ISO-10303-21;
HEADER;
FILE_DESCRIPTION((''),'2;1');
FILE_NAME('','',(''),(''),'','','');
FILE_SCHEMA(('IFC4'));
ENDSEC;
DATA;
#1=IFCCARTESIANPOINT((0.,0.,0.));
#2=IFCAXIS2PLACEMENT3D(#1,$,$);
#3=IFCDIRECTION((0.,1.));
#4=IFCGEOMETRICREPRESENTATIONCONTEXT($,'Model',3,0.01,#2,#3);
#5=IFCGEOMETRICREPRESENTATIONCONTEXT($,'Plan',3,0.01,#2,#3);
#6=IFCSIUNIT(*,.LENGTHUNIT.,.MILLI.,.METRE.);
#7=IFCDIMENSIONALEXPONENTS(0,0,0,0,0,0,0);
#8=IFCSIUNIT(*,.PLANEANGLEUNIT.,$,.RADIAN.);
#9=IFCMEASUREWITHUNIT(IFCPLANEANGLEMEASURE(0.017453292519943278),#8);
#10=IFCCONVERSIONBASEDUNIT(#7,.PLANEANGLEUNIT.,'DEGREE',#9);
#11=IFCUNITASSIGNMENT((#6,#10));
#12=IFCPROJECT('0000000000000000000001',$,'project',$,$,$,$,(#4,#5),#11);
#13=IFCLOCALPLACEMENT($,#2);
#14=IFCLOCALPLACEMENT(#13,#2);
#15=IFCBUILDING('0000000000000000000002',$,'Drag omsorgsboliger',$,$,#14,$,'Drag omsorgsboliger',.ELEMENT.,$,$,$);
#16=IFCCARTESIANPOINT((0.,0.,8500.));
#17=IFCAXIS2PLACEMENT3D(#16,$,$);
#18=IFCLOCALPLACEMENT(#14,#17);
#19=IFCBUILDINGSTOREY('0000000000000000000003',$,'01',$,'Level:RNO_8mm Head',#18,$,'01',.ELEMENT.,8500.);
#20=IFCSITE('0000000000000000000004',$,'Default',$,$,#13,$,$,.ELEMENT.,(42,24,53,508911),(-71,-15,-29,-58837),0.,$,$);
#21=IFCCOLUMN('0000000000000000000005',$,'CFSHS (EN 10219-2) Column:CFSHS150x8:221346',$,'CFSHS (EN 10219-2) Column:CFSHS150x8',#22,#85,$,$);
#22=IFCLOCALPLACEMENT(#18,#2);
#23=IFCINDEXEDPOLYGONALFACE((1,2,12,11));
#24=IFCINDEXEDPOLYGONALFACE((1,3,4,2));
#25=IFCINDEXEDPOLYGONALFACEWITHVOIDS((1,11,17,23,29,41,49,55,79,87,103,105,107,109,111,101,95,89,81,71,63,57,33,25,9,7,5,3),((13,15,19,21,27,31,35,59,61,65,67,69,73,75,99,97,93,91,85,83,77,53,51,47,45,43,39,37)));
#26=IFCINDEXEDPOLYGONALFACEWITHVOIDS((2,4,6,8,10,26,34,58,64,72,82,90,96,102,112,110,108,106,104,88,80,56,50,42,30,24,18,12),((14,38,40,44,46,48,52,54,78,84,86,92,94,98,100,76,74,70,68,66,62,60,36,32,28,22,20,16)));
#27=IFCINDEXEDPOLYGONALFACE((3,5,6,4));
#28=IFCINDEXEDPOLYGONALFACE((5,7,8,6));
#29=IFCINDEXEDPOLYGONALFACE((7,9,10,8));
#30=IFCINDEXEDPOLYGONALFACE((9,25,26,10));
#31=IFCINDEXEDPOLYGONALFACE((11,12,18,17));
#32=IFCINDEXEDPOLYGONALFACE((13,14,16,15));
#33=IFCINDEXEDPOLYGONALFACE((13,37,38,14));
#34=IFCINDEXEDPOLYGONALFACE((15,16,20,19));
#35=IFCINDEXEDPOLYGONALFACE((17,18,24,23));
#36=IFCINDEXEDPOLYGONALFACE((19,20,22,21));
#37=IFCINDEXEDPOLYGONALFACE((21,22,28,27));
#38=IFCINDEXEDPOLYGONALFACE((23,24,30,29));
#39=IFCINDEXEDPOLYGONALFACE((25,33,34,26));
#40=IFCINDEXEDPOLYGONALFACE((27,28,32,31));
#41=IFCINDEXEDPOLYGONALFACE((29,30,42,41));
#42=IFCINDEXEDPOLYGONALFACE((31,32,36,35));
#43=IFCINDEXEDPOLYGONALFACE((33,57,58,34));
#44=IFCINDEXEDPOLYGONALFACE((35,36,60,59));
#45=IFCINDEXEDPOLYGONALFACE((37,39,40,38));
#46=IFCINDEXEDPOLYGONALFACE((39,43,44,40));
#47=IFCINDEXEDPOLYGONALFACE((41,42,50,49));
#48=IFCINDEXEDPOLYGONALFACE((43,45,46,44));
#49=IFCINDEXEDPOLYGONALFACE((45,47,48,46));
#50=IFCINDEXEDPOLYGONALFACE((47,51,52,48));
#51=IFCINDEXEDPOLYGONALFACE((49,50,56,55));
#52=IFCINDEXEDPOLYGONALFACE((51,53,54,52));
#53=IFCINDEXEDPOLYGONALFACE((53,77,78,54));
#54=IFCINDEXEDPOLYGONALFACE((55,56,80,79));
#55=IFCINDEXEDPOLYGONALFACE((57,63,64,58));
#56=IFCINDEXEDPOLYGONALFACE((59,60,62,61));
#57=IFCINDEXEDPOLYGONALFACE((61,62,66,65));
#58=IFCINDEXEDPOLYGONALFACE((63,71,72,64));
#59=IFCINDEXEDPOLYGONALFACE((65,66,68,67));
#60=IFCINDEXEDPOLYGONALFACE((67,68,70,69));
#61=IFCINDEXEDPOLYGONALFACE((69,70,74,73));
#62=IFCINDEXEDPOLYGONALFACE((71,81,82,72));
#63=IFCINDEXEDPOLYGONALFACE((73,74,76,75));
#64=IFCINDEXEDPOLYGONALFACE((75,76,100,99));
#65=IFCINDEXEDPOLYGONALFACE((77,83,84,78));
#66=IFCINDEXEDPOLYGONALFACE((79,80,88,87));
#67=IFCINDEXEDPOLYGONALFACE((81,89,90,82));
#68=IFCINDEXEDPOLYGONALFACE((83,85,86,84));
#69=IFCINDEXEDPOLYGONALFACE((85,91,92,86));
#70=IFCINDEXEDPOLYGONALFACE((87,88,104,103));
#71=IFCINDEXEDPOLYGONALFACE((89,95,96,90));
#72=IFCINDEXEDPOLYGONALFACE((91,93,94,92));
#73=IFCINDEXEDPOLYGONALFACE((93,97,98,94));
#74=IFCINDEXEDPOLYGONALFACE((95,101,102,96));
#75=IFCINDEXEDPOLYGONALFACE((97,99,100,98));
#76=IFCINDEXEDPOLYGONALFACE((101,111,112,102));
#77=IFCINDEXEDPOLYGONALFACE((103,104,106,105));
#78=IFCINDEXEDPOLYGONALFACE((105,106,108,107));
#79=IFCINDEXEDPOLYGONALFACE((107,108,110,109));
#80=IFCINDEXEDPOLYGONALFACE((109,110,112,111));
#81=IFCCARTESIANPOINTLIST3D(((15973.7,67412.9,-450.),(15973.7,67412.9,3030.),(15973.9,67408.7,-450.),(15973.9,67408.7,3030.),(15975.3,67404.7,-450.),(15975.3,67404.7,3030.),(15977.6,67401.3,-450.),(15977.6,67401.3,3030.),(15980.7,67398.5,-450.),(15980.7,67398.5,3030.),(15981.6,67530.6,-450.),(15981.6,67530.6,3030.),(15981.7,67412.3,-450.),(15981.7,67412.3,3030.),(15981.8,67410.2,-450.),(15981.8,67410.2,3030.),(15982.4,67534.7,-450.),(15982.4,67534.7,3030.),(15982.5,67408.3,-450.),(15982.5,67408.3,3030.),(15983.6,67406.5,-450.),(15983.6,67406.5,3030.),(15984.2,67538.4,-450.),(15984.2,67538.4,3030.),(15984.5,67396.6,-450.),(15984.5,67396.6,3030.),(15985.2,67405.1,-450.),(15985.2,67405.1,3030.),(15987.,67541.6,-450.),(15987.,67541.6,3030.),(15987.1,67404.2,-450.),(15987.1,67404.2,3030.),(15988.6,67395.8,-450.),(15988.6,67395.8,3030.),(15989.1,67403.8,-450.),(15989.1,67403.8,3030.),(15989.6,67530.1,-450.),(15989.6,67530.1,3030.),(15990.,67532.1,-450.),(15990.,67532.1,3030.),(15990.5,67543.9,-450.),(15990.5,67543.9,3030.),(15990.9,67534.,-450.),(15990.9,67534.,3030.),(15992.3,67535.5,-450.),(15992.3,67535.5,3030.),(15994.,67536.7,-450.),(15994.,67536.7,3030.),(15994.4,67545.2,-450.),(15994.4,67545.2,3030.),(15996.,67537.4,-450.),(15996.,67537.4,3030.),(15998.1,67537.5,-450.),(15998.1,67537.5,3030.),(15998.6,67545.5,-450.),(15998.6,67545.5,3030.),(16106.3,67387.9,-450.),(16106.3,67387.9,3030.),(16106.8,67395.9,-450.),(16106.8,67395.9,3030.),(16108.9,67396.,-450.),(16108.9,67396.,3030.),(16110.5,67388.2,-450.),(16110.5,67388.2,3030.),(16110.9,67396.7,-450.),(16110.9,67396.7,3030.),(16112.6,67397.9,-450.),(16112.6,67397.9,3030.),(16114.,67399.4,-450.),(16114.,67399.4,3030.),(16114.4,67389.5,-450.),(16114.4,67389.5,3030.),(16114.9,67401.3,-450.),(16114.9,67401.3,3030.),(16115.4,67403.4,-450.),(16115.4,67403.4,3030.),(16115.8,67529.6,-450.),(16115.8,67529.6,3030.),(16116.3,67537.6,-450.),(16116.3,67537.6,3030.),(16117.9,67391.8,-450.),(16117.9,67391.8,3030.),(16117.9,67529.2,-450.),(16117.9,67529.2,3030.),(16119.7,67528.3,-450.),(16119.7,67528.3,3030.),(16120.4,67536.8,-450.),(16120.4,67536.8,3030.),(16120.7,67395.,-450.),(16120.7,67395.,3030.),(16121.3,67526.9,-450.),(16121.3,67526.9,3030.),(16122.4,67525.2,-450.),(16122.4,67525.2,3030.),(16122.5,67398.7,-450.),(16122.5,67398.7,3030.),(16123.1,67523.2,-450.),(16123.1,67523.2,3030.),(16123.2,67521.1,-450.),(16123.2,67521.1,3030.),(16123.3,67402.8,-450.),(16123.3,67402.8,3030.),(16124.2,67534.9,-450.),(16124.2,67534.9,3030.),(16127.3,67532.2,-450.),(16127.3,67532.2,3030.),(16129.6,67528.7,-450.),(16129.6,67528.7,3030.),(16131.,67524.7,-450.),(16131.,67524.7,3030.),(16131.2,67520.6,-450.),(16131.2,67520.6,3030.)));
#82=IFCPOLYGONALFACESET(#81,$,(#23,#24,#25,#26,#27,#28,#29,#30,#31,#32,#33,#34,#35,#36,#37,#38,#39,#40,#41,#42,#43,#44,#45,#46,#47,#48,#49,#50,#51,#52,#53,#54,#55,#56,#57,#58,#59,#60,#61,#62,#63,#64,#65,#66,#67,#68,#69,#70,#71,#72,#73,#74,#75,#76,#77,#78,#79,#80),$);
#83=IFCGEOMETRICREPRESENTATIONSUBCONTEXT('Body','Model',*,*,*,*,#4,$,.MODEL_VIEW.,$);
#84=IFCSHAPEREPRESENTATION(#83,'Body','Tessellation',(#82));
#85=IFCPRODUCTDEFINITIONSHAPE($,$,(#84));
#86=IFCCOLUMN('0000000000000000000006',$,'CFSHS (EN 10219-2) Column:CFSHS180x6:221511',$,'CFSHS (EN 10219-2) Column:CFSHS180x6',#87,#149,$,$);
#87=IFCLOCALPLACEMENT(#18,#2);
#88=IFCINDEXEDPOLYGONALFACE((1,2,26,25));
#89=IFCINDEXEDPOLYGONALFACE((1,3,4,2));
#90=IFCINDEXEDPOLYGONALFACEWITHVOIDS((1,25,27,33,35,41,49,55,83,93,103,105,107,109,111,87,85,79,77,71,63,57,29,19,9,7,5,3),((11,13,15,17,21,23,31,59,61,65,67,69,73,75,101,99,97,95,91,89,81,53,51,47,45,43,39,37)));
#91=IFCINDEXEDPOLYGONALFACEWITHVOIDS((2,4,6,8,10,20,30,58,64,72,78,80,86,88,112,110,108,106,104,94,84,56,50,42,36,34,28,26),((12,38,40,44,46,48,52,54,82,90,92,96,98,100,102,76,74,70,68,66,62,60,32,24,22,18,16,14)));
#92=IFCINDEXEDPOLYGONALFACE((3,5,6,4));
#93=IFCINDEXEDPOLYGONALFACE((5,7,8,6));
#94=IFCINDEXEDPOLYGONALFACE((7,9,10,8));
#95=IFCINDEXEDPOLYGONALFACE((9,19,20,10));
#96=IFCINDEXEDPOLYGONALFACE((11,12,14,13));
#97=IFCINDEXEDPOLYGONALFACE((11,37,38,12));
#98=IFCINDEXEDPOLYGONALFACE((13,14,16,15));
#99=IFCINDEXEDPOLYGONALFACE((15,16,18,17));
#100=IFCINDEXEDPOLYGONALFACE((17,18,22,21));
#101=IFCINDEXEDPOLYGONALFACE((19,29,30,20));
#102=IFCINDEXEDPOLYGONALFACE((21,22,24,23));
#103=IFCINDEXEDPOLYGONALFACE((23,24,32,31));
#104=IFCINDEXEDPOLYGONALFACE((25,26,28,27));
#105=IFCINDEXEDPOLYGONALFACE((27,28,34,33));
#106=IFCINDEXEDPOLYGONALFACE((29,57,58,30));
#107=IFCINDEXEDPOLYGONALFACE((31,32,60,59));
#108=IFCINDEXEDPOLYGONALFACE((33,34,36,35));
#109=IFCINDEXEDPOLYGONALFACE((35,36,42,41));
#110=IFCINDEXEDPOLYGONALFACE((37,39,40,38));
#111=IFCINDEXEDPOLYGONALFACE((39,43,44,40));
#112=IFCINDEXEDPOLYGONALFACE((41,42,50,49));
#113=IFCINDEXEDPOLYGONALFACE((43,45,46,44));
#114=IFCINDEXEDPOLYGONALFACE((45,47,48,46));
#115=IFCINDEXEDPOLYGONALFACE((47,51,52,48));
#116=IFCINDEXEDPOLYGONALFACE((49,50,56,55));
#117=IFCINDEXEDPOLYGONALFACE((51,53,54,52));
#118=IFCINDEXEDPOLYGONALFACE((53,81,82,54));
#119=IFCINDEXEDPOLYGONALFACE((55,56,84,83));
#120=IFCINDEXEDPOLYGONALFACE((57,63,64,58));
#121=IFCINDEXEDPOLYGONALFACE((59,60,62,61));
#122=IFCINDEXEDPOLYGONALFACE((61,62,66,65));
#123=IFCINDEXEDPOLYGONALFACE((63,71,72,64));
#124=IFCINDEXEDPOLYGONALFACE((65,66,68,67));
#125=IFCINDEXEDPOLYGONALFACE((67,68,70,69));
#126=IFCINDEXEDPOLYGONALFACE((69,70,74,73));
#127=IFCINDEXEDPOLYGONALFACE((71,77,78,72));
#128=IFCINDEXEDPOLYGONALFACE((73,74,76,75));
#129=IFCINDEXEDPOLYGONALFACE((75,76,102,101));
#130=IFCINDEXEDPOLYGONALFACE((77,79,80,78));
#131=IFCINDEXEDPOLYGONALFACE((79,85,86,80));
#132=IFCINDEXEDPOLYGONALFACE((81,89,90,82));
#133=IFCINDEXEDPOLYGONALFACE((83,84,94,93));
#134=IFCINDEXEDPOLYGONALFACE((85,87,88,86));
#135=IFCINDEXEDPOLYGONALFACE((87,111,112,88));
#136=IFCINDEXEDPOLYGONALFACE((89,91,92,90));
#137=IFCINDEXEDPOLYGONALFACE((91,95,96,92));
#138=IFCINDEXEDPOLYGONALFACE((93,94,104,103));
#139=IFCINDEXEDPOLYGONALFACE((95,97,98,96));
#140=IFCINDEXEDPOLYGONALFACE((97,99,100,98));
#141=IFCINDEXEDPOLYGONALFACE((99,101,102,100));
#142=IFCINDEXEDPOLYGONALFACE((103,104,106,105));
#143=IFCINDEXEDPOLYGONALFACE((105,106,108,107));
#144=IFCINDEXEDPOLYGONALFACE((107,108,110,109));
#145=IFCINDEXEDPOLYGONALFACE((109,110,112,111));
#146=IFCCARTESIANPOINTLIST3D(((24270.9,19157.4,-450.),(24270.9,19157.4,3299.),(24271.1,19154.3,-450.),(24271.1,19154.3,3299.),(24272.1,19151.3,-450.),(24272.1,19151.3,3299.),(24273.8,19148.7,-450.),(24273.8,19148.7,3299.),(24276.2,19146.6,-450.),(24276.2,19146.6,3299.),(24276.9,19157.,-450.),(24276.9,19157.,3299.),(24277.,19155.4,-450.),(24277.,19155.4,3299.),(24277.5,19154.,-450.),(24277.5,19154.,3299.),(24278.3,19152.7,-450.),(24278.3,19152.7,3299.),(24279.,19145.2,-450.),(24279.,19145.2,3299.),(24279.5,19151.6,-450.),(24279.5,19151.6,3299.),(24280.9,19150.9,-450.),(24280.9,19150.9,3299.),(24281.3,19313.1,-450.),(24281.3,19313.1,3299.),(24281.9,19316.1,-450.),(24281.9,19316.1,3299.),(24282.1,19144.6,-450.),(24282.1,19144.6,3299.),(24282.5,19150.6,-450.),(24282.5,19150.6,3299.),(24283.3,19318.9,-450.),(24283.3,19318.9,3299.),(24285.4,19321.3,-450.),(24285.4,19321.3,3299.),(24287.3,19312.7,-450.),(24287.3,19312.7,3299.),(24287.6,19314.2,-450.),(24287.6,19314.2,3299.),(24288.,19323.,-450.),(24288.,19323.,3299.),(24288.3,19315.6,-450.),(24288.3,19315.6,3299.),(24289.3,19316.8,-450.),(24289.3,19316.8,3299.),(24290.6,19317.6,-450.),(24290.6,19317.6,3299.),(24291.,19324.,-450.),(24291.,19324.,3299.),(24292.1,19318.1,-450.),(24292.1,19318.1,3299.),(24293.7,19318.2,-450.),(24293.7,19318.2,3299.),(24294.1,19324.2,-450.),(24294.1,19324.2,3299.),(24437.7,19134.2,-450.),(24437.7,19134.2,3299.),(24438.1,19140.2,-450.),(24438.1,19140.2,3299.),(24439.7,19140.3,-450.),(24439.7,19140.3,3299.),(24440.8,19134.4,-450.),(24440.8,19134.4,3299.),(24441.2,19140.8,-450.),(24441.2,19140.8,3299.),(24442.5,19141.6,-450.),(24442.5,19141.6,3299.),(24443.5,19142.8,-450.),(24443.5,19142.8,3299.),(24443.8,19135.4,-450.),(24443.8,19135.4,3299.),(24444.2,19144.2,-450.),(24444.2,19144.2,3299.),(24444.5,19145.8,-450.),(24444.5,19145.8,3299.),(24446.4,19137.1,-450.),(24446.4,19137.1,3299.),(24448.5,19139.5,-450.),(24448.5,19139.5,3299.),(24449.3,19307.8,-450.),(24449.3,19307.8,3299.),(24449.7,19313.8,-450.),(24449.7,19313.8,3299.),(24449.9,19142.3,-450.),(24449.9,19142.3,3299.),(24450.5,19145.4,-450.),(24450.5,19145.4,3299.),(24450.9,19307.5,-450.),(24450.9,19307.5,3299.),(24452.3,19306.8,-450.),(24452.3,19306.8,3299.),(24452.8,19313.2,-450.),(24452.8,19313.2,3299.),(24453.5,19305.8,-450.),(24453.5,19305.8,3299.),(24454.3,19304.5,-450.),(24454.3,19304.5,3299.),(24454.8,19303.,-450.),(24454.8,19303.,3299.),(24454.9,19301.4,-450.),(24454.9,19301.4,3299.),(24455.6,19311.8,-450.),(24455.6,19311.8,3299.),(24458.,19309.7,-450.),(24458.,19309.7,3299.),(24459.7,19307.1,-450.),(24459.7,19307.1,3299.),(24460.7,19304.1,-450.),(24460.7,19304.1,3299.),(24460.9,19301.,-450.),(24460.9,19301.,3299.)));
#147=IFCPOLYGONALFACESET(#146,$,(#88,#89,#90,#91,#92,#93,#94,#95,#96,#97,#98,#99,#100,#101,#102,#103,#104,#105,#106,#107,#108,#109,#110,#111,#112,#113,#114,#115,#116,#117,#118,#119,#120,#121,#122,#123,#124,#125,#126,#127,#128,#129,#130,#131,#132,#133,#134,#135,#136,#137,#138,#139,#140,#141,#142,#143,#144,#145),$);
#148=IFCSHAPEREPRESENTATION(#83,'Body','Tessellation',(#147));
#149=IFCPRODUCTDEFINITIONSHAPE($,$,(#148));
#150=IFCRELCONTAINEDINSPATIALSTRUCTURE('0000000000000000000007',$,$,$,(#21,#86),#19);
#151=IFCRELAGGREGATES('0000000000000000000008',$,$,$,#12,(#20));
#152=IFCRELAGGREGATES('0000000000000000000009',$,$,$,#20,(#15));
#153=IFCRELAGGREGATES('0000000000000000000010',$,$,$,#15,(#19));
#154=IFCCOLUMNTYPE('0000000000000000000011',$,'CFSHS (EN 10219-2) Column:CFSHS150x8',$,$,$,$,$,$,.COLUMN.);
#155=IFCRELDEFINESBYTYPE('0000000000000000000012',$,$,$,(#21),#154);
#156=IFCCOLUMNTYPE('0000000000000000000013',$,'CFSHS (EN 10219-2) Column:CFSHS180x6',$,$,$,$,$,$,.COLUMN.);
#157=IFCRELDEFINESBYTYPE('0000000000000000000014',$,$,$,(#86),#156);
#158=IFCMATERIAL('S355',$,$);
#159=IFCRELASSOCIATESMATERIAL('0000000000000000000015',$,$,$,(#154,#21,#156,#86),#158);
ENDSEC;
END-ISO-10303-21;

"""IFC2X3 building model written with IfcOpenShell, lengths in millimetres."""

from ifc_helpers import new_model, entity, si_unit, converted_unit, direction, frame, frame_2d, origin, place, context, subcontext, project, spatial, polyline, circle_curve, parameter, trimmed, segment, composite_curve, outline, extrude, source, transform, mapped, material, type_object, type_shapes, element, save


model = new_model("IFC2X3")

# Units and contexts
model_context = context("Model", 3, precision=0.01, world=origin(), true_north=direction((0.0, 1.0)))
plan_context = context("Plan", 3, precision=0.01, world=origin(), true_north=direction((0.0, 1.0)))
body_context = subcontext(model_context, "Body", "Model", "MODEL_VIEW")
ifc_project = project(units=[si_unit("LENGTHUNIT", "METRE", prefix="MILLI"), converted_unit("PLANEANGLEUNIT", "DEGREE", entity("IfcPlaneAngleMeasure", 0.017453292519943278), si_unit("PLANEANGLEUNIT", "RADIAN"), dimensions=[0, 0, 0, 0, 0, 0, 0])], contexts=[model_context, plan_context])

# Site, building, storey
site_placement = place(None, origin())
site = spatial("IfcSite", under=ifc_project, at=site_placement, Name="Default", CompositionType="ELEMENT", RefLatitude=(42, 24, 53, 508911), RefLongitude=(-71, -15, -29, -58837), RefElevation=0.0)
building_placement = place(site_placement, origin())
building = spatial("IfcBuilding", under=site, at=building_placement, Name="Drag omsorgsboliger", LongName="Drag omsorgsboliger", CompositionType="ELEMENT")
storey_placement = place(building_placement, frame((0.0, 0.0, 8500.0)))
storey = spatial("IfcBuildingStorey", under=building, at=storey_placement, Name="01", ObjectType="Level:RNO_8mm Head", LongName="01", CompositionType="ELEMENT", Elevation=8500.0)

# Columns
ifc_material = material(Name="S355")
column_type_1 = type_object("IfcColumnType", Name="CFSHS (EN 10219-2) Column:CFSHS150x8", PredefinedType="COLUMN", material=ifc_material)
shared_shape_1 = source(origin(), body_context, "Body", "SweptSolid", [
    extrude(outline(composite_curve([segment(polyline([(-59.0, -75.0), (59.0, -75.0)]), True, "CONTINUOUS"), segment(trimmed(circle_curve(frame_2d((59.0, -59.0), x_axis=(-1.0, 0.0)), 16.0), [parameter(90.0)], [parameter(180.0)], True, "PARAMETER"), True, "CONTINUOUS"), segment(polyline([(75.0, -59.0), (75.0, 59.0)]), True, "CONTINUOUS"), segment(trimmed(circle_curve(frame_2d((59.0, 59.0), x_axis=(-1.0, 0.0)), 16.0), [parameter(180.0)], [parameter(270.0)], True, "PARAMETER"), True, "CONTINUOUS"), segment(polyline([(59.0, 75.0), (-59.0, 75.0)]), True, "CONTINUOUS"), segment(trimmed(circle_curve(frame_2d((-59.0, 59.0), x_axis=(-1.0, 0.0)), 16.0), [parameter(270.0)], [parameter(360.0)], True, "PARAMETER"), True, "CONTINUOUS"), segment(polyline([(-75.0, 59.0), (-75.0, -59.0)]), True, "CONTINUOUS"), segment(trimmed(circle_curve(frame_2d((-59.0, -59.0), x_axis=(-1.0, 0.0)), 16.0), [parameter(360.0)], [parameter(90.0)], True, "PARAMETER"), True, "CONTINUOUS")], self_intersect=False), holes=[composite_curve([segment(trimmed(circle_curve(frame_2d((-59.0, -59.0), x_axis=(-1.0, 0.0)), 8.0), [parameter(360.0)], [parameter(90.0)], True, "PARAMETER"), False, "CONTINUOUS"), segment(polyline([(-67.0, -59.0), (-67.0, 59.0)]), True, "CONTINUOUS"), segment(trimmed(circle_curve(frame_2d((-59.0, 59.0), x_axis=(-1.0, 0.0)), 8.0), [parameter(270.0)], [parameter(360.0)], True, "PARAMETER"), False, "CONTINUOUS"), segment(polyline([(-59.0, 67.0), (59.0, 67.0)]), True, "CONTINUOUS"), segment(trimmed(circle_curve(frame_2d((59.0, 59.0), x_axis=(-1.0, 0.0)), 8.0), [parameter(180.0)], [parameter(270.0)], True, "PARAMETER"), False, "CONTINUOUS"), segment(polyline([(67.0, 59.0), (67.0, -59.0)]), True, "CONTINUOUS"), segment(trimmed(circle_curve(frame_2d((59.0, -59.0), x_axis=(-1.0, 0.0)), 8.0), [parameter(90.0)], [parameter(180.0)], True, "PARAMETER"), False, "CONTINUOUS"), segment(polyline([(59.0, -67.0), (-59.0, -67.0)]), True, "CONTINUOUS")], self_intersect=False)]), frame((16052.5, 67466.7, 8050.0), z_axis=(0.0, 0.0, 1.0), x_axis=(-0.997758, 0.066923, 0.0)), (0.0, 0.0, 1.0), 3480.0),
])
type_shapes(column_type_1, [shared_shape_1])
column_1_placement = place(storey_placement, frame((0.0, 0.0, -8500.0)))
element("IfcColumn", 1, at=column_1_placement, inside=storey, type_object=column_type_1, material=ifc_material, Name="CFSHS (EN 10219-2) Column:CFSHS150x8:221346", ObjectType="CFSHS (EN 10219-2) Column:CFSHS150x8", context=body_context, shape_type="MappedRepresentation", body=[
    mapped(shared_shape_1, transform((0.0, 0.0, 0.0), scale=1.0)),
])
column_type_2 = type_object("IfcColumnType", Name="CFSHS (EN 10219-2) Column:CFSHS180x6", PredefinedType="COLUMN", material=ifc_material)
shared_shape_2 = source(origin(), body_context, "Body", "SweptSolid", [
    extrude(outline(composite_curve([segment(polyline([(-78.0, -90.0), (78.0, -90.0)]), True, "CONTINUOUS"), segment(trimmed(circle_curve(frame_2d((78.0, -78.0), x_axis=(-1.0, 0.0)), 12.0), [parameter(90.0)], [parameter(180.0)], True, "PARAMETER"), True, "CONTINUOUS"), segment(polyline([(90.0, -78.0), (90.0, 78.0)]), True, "CONTINUOUS"), segment(trimmed(circle_curve(frame_2d((78.0, 78.0), x_axis=(-1.0, 0.0)), 12.0), [parameter(180.0)], [parameter(270.0)], True, "PARAMETER"), True, "CONTINUOUS"), segment(polyline([(78.0, 90.0), (-78.0, 90.0)]), True, "CONTINUOUS"), segment(trimmed(circle_curve(frame_2d((-78.0, 78.0), x_axis=(-1.0, 0.0)), 12.0), [parameter(270.0)], [parameter(360.0)], True, "PARAMETER"), True, "CONTINUOUS"), segment(polyline([(-90.0, 78.0), (-90.0, -78.0)]), True, "CONTINUOUS"), segment(trimmed(circle_curve(frame_2d((-78.0, -78.0), x_axis=(-1.0, 0.0)), 12.0), [parameter(360.0)], [parameter(90.0)], True, "PARAMETER"), True, "CONTINUOUS")], self_intersect=False), holes=[composite_curve([segment(trimmed(circle_curve(frame_2d((-78.0, -78.0), x_axis=(-1.0, 0.0)), 6.0), [parameter(360.0)], [parameter(90.0)], True, "PARAMETER"), False, "CONTINUOUS"), segment(polyline([(-84.0, -78.0), (-84.0, 78.0)]), True, "CONTINUOUS"), segment(trimmed(circle_curve(frame_2d((-78.0, 78.0), x_axis=(-1.0, 0.0)), 6.0), [parameter(270.0)], [parameter(360.0)], True, "PARAMETER"), False, "CONTINUOUS"), segment(polyline([(-78.0, 84.0), (78.0, 84.0)]), True, "CONTINUOUS"), segment(trimmed(circle_curve(frame_2d((78.0, 78.0), x_axis=(-1.0, 0.0)), 6.0), [parameter(180.0)], [parameter(270.0)], True, "PARAMETER"), False, "CONTINUOUS"), segment(polyline([(84.0, 78.0), (84.0, -78.0)]), True, "CONTINUOUS"), segment(trimmed(circle_curve(frame_2d((78.0, -78.0), x_axis=(-1.0, 0.0)), 6.0), [parameter(90.0)], [parameter(180.0)], True, "PARAMETER"), False, "CONTINUOUS"), segment(polyline([(78.0, -84.0), (-78.0, -84.0)]), True, "CONTINUOUS")], self_intersect=False)]), frame((24365.9, 19229.2, 8050.0), z_axis=(0.0, 0.0, 1.0), x_axis=(-0.997758, 0.066923, 0.0)), (0.0, 0.0, 1.0), 3749.0),
])
type_shapes(column_type_2, [shared_shape_2])
column_2_placement = place(storey_placement, frame((0.0, 0.0, -8500.0)))
element("IfcColumn", 2, at=column_2_placement, inside=storey, type_object=column_type_2, material=ifc_material, Name="CFSHS (EN 10219-2) Column:CFSHS180x6:221511", ObjectType="CFSHS (EN 10219-2) Column:CFSHS180x6", context=body_context, shape_type="MappedRepresentation", body=[
    mapped(shared_shape_2, transform((0.0, 0.0, 0.0), scale=1.0)),
])

save(model, "model.ifc")
